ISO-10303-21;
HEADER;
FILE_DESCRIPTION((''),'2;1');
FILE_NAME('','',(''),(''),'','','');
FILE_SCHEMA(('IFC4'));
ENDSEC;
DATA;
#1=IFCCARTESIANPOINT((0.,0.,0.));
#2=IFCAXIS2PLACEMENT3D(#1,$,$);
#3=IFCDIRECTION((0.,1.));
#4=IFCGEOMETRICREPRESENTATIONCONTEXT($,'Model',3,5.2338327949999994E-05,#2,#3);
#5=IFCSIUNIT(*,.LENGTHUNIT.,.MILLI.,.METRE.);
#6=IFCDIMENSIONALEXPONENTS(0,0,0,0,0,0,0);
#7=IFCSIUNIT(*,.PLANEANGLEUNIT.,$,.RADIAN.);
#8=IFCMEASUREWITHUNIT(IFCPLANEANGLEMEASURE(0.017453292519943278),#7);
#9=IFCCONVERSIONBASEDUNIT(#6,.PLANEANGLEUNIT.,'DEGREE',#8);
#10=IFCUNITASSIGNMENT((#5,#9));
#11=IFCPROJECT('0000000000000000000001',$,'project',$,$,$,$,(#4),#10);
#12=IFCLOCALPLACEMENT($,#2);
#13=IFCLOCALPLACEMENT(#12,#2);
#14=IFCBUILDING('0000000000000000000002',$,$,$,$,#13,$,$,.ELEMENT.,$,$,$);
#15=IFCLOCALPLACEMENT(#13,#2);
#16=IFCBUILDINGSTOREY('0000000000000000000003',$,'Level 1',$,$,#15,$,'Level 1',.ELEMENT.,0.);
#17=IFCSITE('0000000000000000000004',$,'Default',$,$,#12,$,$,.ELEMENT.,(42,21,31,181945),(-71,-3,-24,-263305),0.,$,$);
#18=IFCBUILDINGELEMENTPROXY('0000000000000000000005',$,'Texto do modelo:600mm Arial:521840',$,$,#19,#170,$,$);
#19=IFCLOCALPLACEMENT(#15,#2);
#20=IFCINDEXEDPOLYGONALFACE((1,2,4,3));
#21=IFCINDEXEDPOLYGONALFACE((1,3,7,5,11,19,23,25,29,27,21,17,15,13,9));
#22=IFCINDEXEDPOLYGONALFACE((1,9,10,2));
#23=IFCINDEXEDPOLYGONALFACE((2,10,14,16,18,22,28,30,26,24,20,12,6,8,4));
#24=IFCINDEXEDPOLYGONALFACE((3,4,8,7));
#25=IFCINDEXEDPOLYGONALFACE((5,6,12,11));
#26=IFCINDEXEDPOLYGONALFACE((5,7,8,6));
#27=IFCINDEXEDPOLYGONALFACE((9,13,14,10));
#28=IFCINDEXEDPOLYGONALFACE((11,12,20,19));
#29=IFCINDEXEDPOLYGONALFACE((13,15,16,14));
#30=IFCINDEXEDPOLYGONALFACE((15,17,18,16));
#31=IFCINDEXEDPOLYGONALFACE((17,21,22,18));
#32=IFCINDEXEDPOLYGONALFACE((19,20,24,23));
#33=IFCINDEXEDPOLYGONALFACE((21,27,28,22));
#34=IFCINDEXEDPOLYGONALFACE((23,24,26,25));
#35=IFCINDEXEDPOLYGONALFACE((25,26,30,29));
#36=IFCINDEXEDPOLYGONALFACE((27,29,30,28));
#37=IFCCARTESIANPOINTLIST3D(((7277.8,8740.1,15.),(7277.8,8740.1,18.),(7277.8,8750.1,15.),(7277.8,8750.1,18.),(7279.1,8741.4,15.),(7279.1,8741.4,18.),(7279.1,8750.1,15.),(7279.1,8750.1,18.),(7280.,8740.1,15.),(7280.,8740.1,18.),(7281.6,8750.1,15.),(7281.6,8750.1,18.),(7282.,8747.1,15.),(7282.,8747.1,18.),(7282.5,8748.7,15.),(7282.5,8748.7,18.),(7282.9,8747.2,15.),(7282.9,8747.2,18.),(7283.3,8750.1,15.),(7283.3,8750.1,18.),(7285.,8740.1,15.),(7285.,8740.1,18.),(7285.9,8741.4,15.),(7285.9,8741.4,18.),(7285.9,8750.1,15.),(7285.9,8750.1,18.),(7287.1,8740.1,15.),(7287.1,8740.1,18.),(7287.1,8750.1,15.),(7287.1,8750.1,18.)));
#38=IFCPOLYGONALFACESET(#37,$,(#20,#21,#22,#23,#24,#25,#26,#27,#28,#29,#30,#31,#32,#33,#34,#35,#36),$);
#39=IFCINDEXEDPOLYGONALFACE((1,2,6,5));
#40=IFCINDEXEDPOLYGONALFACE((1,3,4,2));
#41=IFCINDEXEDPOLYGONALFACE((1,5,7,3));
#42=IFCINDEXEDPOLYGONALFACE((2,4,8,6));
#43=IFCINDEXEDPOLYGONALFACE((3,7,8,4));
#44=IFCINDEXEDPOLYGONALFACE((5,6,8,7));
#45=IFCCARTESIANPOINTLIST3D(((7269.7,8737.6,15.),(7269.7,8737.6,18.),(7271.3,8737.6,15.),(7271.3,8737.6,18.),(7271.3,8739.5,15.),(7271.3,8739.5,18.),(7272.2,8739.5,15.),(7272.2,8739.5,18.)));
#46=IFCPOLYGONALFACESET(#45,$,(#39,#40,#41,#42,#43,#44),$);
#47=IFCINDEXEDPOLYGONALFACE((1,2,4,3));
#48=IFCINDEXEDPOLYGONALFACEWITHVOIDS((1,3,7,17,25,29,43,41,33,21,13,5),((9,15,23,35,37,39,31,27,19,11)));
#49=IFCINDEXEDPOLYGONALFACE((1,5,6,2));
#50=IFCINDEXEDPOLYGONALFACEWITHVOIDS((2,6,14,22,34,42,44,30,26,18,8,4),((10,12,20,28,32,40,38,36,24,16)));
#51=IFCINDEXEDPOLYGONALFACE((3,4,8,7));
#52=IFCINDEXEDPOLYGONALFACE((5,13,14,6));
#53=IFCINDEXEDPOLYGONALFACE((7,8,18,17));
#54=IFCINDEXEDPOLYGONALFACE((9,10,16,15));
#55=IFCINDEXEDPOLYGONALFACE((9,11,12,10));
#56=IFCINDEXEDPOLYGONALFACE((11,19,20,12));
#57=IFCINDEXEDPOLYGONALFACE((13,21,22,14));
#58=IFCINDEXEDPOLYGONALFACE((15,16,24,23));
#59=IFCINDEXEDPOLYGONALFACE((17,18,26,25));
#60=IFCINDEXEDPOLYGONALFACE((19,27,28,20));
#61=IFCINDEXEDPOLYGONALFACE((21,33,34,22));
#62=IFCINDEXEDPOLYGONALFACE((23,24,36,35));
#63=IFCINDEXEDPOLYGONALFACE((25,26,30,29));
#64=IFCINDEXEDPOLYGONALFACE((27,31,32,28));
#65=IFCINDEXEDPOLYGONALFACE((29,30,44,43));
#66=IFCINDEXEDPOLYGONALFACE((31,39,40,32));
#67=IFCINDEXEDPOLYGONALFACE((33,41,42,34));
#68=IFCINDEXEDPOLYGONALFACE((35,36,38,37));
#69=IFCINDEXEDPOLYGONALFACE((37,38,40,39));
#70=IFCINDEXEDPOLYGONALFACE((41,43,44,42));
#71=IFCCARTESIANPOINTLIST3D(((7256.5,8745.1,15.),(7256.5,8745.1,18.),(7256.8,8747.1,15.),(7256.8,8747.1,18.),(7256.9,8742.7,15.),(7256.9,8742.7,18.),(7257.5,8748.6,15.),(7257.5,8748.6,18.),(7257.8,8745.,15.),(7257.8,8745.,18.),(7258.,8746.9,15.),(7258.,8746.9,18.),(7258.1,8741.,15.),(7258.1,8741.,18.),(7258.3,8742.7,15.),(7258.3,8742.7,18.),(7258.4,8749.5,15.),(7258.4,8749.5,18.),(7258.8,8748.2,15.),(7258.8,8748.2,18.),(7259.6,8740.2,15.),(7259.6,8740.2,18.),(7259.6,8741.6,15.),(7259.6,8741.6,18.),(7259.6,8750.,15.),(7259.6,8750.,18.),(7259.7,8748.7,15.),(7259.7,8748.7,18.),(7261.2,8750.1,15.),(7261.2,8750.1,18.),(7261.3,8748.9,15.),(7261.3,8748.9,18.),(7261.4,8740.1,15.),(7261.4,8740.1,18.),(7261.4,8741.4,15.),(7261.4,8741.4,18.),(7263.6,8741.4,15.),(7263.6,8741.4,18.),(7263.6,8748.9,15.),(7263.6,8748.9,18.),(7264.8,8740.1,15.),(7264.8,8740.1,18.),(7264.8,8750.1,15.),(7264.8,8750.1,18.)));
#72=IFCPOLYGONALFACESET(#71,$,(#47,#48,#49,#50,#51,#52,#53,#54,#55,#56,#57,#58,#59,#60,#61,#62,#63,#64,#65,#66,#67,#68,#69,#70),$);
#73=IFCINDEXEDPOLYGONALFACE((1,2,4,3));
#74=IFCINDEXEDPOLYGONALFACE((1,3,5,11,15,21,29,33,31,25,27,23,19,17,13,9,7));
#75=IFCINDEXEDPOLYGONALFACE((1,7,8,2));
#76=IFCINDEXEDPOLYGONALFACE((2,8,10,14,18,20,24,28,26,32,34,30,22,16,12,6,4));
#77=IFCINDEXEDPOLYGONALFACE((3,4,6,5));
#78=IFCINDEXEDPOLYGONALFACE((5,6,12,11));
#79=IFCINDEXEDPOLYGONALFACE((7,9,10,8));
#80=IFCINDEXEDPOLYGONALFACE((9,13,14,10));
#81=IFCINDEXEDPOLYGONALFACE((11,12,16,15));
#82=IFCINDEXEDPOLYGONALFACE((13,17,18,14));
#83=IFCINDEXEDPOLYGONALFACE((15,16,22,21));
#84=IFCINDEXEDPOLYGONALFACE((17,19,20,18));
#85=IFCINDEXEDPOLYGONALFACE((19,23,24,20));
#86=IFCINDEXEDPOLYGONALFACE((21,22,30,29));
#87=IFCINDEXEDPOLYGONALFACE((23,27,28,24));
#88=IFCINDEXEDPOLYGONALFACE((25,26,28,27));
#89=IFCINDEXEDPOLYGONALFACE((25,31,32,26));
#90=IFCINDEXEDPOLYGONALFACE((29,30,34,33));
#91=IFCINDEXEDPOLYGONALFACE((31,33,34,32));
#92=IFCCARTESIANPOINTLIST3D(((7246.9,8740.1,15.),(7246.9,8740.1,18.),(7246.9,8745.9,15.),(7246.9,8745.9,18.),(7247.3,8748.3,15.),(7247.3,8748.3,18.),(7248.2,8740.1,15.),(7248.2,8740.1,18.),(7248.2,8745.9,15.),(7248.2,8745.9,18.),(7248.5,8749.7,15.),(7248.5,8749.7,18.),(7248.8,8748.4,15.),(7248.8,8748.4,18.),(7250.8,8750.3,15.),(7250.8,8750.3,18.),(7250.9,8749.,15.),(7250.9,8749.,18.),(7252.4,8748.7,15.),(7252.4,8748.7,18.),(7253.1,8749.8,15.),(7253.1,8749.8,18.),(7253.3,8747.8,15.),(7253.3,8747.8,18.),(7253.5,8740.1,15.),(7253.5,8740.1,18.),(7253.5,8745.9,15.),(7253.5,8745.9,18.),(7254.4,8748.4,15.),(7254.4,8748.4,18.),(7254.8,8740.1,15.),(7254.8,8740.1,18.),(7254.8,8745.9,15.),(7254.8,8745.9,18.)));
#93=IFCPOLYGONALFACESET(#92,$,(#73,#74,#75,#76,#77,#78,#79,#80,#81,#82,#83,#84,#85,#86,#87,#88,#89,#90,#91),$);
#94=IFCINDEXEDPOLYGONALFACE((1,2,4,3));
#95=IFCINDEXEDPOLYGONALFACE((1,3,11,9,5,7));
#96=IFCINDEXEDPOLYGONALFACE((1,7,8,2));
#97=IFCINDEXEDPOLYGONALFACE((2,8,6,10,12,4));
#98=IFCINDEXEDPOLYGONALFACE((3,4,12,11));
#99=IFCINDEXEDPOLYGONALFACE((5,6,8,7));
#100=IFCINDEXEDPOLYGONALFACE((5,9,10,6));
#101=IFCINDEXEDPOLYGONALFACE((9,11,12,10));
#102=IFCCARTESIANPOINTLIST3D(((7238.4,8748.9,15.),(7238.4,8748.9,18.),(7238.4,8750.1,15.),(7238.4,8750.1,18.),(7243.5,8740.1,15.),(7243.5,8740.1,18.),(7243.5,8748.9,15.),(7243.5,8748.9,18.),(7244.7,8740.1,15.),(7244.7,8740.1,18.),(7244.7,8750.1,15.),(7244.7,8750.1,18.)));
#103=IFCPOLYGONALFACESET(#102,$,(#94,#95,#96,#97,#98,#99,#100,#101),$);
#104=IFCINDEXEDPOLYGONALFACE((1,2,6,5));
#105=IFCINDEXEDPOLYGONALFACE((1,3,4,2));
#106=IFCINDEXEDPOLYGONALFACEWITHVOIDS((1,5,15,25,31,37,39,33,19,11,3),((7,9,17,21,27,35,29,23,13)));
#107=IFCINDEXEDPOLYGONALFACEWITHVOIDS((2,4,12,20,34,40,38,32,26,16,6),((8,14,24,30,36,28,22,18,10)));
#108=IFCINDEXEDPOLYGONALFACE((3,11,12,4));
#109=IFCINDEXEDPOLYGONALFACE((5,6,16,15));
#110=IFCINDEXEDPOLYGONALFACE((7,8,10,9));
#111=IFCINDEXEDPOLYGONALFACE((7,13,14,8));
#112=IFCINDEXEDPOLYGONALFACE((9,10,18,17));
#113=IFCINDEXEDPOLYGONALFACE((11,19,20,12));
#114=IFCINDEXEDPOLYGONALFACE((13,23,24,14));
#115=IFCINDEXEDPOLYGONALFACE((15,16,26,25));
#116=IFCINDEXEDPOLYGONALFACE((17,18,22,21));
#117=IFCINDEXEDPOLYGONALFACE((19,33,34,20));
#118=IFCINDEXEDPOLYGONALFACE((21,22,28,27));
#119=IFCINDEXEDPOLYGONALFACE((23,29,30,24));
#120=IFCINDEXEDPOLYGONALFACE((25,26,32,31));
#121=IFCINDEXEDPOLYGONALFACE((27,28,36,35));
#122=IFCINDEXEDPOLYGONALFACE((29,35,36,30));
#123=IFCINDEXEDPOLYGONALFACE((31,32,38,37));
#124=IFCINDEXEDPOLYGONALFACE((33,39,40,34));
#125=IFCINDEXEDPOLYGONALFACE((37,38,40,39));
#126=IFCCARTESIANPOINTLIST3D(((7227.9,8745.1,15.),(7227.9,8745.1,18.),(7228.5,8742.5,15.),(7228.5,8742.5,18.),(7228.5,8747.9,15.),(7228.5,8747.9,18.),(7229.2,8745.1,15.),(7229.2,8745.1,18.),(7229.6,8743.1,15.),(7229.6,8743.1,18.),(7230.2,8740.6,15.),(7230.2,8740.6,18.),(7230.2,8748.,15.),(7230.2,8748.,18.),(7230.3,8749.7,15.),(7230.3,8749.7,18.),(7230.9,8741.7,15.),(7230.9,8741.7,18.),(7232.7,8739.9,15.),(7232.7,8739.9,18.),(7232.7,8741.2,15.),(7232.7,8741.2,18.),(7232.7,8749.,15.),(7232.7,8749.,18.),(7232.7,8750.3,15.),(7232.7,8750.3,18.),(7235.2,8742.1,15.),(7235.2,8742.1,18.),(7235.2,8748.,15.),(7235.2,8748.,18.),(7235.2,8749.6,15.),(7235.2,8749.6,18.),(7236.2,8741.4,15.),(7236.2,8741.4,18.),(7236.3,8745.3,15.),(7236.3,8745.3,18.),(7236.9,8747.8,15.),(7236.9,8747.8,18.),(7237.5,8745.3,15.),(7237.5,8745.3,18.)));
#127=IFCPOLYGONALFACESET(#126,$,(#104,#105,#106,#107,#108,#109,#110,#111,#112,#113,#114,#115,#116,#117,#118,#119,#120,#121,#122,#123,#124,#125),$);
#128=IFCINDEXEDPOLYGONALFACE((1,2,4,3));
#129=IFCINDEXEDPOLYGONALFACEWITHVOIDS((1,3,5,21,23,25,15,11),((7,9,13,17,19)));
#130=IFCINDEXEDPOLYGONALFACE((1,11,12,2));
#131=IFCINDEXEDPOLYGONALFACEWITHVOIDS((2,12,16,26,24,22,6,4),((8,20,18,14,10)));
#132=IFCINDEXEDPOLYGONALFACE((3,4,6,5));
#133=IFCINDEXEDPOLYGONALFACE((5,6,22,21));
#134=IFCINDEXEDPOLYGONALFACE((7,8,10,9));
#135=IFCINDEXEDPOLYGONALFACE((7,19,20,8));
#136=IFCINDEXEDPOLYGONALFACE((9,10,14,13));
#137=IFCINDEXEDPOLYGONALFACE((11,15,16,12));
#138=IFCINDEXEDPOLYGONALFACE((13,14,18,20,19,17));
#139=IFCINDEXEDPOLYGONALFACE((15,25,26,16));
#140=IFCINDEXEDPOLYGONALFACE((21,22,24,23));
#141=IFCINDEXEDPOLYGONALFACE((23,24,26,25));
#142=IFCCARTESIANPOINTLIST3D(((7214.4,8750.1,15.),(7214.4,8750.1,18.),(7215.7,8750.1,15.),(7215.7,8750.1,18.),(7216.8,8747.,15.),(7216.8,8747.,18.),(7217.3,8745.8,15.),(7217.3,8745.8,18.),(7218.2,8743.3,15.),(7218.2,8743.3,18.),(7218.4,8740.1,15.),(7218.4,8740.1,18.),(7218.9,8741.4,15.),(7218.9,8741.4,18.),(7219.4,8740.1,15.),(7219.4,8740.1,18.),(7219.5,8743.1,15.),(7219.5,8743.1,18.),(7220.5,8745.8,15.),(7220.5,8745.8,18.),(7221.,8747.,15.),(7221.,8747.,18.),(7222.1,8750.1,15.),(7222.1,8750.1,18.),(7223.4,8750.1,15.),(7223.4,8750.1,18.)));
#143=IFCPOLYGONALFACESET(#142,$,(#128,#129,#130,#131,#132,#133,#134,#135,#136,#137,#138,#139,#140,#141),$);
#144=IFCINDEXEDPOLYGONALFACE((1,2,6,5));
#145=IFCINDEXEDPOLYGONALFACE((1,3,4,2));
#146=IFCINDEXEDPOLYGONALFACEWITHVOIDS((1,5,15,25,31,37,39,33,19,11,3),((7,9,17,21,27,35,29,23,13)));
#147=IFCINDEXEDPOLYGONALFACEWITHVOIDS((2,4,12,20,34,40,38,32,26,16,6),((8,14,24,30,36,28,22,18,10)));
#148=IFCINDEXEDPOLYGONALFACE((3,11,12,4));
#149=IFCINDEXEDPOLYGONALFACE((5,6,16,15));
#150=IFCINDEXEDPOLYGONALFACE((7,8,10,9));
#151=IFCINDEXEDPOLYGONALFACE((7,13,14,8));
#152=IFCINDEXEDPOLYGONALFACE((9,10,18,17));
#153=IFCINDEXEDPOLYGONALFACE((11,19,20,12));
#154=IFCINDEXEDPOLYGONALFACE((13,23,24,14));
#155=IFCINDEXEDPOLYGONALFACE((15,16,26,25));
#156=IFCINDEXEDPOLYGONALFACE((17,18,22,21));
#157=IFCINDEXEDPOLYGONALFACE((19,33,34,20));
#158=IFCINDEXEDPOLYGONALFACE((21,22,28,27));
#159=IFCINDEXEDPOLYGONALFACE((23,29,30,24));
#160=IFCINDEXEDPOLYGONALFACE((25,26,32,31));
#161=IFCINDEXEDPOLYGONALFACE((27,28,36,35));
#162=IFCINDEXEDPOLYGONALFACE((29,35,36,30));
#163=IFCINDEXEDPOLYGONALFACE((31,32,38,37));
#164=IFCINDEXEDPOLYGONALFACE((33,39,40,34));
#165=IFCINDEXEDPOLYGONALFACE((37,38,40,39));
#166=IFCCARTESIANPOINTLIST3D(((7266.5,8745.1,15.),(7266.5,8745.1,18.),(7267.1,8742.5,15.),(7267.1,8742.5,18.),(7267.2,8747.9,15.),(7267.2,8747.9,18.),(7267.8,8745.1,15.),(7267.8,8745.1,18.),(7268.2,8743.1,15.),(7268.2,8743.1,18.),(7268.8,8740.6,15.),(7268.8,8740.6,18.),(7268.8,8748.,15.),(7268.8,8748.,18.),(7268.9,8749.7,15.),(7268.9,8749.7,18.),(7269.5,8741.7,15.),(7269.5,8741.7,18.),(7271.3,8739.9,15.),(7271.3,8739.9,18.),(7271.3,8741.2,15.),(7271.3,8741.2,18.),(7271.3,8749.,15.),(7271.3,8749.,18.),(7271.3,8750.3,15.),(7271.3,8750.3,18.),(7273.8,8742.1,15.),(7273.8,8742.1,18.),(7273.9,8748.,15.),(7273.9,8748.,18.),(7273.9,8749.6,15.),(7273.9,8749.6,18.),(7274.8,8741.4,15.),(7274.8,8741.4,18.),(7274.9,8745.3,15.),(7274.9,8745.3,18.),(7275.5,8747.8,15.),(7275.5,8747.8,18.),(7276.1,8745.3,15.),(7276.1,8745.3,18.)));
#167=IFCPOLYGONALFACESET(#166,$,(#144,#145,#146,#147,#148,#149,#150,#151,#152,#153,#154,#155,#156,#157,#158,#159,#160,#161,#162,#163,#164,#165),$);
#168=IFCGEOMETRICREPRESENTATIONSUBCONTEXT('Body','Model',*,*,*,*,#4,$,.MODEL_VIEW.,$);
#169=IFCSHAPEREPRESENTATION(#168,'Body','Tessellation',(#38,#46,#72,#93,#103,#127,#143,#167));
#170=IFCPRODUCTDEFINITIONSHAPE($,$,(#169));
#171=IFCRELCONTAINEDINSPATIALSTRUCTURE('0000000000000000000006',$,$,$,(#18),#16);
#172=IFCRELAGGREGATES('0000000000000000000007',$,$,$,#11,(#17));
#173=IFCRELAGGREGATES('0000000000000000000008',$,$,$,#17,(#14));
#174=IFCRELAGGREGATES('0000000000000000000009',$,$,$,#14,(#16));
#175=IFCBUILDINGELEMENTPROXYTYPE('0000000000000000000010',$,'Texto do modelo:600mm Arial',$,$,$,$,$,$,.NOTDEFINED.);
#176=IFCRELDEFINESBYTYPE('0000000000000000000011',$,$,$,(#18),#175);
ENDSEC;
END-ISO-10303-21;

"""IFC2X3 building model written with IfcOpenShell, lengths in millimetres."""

from ifc_helpers import new_model, entity, si_unit, converted_unit, direction, frame, origin, place, context, subcontext, project, spatial, polyline, outline, extrude, type_object, element, save


model = new_model("IFC2X3")

# Units and contexts
model_context = context("Model", 3, precision=5.2338327949999994e-05, world=origin(), true_north=direction((0.0, 1.0)))
body_context = subcontext(model_context, "Body", "Model", "MODEL_VIEW")
ifc_project = project(units=[si_unit("LENGTHUNIT", "METRE", prefix="MILLI"), converted_unit("PLANEANGLEUNIT", "DEGREE", entity("IfcPlaneAngleMeasure", 0.017453292519943278), si_unit("PLANEANGLEUNIT", "RADIAN"), dimensions=[0, 0, 0, 0, 0, 0, 0])], contexts=[model_context])

# Site, building, storey
site_placement = place(None, origin())
site = spatial("IfcSite", under=ifc_project, at=site_placement, Name="Default", CompositionType="ELEMENT", RefLatitude=(42, 21, 31, 181945), RefLongitude=(-71, -3, -24, -263305), RefElevation=0.0)
building_placement = place(site_placement, origin())
building = spatial("IfcBuilding", under=site, at=building_placement, CompositionType="ELEMENT")
storey_placement = place(building_placement, origin())
storey = spatial("IfcBuildingStorey", under=building, at=storey_placement, Name="Level 1", LongName="Level 1", CompositionType="ELEMENT", Elevation=0.0)

# Building element proxy
building_element_proxy_type_1 = type_object("IfcBuildingElementProxyType", Name="Texto do modelo:600mm Arial", PredefinedType="NOTDEFINED")
proxy_1_placement = place(storey_placement, origin())
element("IfcBuildingElementProxy", 1, at=proxy_1_placement, inside=storey, type_object=building_element_proxy_type_1, Name="Texto do modelo:600mm Arial:521840", context=body_context, shape_type="SweptSolid", body=[
    extrude(outline(polyline([(-4.6, -4.4), (-3.4, -4.4), (-3.4, 4.4), (-0.9, -4.4), (0.8, -4.4), (3.4, 4.4), (3.4, -4.4), (4.6, -4.4), (4.6, 5.7), (2.5, 5.7), (0.4, -1.3), (0.0, -2.9), (-0.4, -1.4), (-2.5, 5.7), (-4.6, 5.7), (-4.6, -4.4)])), frame((7282.5, 8745.8, 15.0), z_axis=(0.0, 0.0, 1.0), x_axis=(-1.0, 0.0, 0.0)), (0.0, 0.0, 1.0), 3.0),
    extrude(outline(polyline([(-1.1, -0.9), (-0.2, -0.9), (1.4, 0.9), (-0.2, 0.9), (-1.1, -0.9)])), frame((7271.1, 8738.5, 15.0), z_axis=(0.0, 0.0, 1.0), x_axis=(-1.0, 0.0, 0.0)), (0.0, 0.0, 1.0), 3.0),
    extrude(outline(polyline([(-5.2, -4.8), (-1.6, -4.8), (0.0, -4.6), (1.2, -4.1), (2.2, -3.2), (2.8, -1.7), (3.1, 0.3), (2.7, 2.7), (1.5, 4.4), (0.1, 5.1), (-1.7, 5.3), (-5.2, 5.3), (-5.2, -4.8)]), holes=[polyline([(-3.9, -3.5), (-3.9, 4.0), (-1.8, 4.0), (0.0, 3.8), (1.3, 2.7), (1.9, 0.3), (1.6, -1.6), (0.8, -2.8), (-0.1, -3.3), (-1.7, -3.5), (-3.9, -3.5)])]), frame((7259.6, 8745.4, 15.0), z_axis=(0.0, 0.0, 1.0), x_axis=(-1.0, 0.0, 0.0)), (0.0, 0.0, 1.0), 3.0),
    extrude(outline(polyline([(-6.0, -2.8), (-6.0, -4.0), (-0.2, -4.0), (2.2, -3.7), (3.6, -2.5), (4.2, -0.1), (3.7, 2.2), (2.3, 3.4), (-0.2, 3.8), (-6.0, 3.8), (-6.0, 2.6), (-0.3, 2.6), (1.6, 2.3), (2.6, 1.5), (2.9, 0.0), (2.2, -2.1), (-0.3, -2.8), (-6.0, -2.8)])), frame((7251.0, 8746.1, 15.0), z_axis=(0.0, 0.0, -1.0), x_axis=(0.0, 1.0, 0.0)), (0.0, 0.0, -1.0), 3.0),
    extrude(outline(polyline([(-2.5, -3.8), (3.8, -3.8), (3.8, -2.5), (-1.3, -2.5), (-1.3, 6.3), (-2.5, 6.3), (-2.5, -3.8)])), frame((7242.2, 8746.4, 15.0), z_axis=(0.0, 0.0, 1.0), x_axis=(-1.0, 0.0, 0.0)), (0.0, 0.0, 1.0), 3.0),
    extrude(outline(polyline([(-1.3, -4.9), (1.2, -4.9), (3.4, -3.7), (4.7, -1.4), (4.6, 1.1), (3.2, 3.2), (0.7, 4.5), (-2.0, 4.5), (-4.2, 3.2), (-5.4, 1.0), (-4.8, -2.7), (-1.3, -4.9)]), holes=[polyline([(-1.0, -3.7), (-3.9, -2.0), (-4.2, 0.7), (-3.3, 2.4), (-1.7, 3.3), (0.4, 3.2), (3.0, 1.6), (3.4, -1.1), (1.9, -3.3), (-1.0, -3.7)])]), frame((7232.4, 8745.5, 15.0), z_axis=(0.0, 0.0, 1.0), x_axis=(-0.223707, 0.974656, 0.0)), (0.0, 0.0, 1.0), 3.0),
    extrude(outline(polyline([(-4.5, -3.3), (-3.2, -3.3), (-2.1, -0.2), (2.1, -0.2), (3.2, -3.3), (4.5, -3.3), (0.5, 6.7), (-0.5, 6.7), (-4.5, -3.3)]), holes=[polyline([(-1.6, 1.1), (-0.6, 3.8), (0.0, 5.5), (0.7, 3.6), (1.6, 1.1), (-1.6, 1.1)])]), frame((7218.9, 8746.8, 15.0), z_axis=(0.0, 0.0, 1.0), x_axis=(-1.0, 0.0, 0.0)), (0.0, 0.0, 1.0), 3.0),
    extrude(outline(polyline([(-1.3, -4.9), (1.2, -4.9), (3.4, -3.7), (4.7, -1.4), (4.6, 1.1), (3.2, 3.2), (0.7, 4.5), (-2.0, 4.5), (-4.2, 3.2), (-5.4, 1.0), (-4.8, -2.7), (-1.3, -4.9)]), holes=[polyline([(-1.0, -3.7), (-3.9, -2.0), (-4.2, 0.7), (-3.3, 2.4), (-1.7, 3.3), (0.4, 3.2), (3.0, 1.6), (3.4, -1.1), (1.9, -3.3), (-1.0, -3.7)])]), frame((7271.0, 8745.5, 15.0), z_axis=(0.0, 0.0, 1.0), x_axis=(-0.223707, 0.974656, 0.0)), (0.0, 0.0, 1.0), 3.0),
])

save(model, "model.ifc")
